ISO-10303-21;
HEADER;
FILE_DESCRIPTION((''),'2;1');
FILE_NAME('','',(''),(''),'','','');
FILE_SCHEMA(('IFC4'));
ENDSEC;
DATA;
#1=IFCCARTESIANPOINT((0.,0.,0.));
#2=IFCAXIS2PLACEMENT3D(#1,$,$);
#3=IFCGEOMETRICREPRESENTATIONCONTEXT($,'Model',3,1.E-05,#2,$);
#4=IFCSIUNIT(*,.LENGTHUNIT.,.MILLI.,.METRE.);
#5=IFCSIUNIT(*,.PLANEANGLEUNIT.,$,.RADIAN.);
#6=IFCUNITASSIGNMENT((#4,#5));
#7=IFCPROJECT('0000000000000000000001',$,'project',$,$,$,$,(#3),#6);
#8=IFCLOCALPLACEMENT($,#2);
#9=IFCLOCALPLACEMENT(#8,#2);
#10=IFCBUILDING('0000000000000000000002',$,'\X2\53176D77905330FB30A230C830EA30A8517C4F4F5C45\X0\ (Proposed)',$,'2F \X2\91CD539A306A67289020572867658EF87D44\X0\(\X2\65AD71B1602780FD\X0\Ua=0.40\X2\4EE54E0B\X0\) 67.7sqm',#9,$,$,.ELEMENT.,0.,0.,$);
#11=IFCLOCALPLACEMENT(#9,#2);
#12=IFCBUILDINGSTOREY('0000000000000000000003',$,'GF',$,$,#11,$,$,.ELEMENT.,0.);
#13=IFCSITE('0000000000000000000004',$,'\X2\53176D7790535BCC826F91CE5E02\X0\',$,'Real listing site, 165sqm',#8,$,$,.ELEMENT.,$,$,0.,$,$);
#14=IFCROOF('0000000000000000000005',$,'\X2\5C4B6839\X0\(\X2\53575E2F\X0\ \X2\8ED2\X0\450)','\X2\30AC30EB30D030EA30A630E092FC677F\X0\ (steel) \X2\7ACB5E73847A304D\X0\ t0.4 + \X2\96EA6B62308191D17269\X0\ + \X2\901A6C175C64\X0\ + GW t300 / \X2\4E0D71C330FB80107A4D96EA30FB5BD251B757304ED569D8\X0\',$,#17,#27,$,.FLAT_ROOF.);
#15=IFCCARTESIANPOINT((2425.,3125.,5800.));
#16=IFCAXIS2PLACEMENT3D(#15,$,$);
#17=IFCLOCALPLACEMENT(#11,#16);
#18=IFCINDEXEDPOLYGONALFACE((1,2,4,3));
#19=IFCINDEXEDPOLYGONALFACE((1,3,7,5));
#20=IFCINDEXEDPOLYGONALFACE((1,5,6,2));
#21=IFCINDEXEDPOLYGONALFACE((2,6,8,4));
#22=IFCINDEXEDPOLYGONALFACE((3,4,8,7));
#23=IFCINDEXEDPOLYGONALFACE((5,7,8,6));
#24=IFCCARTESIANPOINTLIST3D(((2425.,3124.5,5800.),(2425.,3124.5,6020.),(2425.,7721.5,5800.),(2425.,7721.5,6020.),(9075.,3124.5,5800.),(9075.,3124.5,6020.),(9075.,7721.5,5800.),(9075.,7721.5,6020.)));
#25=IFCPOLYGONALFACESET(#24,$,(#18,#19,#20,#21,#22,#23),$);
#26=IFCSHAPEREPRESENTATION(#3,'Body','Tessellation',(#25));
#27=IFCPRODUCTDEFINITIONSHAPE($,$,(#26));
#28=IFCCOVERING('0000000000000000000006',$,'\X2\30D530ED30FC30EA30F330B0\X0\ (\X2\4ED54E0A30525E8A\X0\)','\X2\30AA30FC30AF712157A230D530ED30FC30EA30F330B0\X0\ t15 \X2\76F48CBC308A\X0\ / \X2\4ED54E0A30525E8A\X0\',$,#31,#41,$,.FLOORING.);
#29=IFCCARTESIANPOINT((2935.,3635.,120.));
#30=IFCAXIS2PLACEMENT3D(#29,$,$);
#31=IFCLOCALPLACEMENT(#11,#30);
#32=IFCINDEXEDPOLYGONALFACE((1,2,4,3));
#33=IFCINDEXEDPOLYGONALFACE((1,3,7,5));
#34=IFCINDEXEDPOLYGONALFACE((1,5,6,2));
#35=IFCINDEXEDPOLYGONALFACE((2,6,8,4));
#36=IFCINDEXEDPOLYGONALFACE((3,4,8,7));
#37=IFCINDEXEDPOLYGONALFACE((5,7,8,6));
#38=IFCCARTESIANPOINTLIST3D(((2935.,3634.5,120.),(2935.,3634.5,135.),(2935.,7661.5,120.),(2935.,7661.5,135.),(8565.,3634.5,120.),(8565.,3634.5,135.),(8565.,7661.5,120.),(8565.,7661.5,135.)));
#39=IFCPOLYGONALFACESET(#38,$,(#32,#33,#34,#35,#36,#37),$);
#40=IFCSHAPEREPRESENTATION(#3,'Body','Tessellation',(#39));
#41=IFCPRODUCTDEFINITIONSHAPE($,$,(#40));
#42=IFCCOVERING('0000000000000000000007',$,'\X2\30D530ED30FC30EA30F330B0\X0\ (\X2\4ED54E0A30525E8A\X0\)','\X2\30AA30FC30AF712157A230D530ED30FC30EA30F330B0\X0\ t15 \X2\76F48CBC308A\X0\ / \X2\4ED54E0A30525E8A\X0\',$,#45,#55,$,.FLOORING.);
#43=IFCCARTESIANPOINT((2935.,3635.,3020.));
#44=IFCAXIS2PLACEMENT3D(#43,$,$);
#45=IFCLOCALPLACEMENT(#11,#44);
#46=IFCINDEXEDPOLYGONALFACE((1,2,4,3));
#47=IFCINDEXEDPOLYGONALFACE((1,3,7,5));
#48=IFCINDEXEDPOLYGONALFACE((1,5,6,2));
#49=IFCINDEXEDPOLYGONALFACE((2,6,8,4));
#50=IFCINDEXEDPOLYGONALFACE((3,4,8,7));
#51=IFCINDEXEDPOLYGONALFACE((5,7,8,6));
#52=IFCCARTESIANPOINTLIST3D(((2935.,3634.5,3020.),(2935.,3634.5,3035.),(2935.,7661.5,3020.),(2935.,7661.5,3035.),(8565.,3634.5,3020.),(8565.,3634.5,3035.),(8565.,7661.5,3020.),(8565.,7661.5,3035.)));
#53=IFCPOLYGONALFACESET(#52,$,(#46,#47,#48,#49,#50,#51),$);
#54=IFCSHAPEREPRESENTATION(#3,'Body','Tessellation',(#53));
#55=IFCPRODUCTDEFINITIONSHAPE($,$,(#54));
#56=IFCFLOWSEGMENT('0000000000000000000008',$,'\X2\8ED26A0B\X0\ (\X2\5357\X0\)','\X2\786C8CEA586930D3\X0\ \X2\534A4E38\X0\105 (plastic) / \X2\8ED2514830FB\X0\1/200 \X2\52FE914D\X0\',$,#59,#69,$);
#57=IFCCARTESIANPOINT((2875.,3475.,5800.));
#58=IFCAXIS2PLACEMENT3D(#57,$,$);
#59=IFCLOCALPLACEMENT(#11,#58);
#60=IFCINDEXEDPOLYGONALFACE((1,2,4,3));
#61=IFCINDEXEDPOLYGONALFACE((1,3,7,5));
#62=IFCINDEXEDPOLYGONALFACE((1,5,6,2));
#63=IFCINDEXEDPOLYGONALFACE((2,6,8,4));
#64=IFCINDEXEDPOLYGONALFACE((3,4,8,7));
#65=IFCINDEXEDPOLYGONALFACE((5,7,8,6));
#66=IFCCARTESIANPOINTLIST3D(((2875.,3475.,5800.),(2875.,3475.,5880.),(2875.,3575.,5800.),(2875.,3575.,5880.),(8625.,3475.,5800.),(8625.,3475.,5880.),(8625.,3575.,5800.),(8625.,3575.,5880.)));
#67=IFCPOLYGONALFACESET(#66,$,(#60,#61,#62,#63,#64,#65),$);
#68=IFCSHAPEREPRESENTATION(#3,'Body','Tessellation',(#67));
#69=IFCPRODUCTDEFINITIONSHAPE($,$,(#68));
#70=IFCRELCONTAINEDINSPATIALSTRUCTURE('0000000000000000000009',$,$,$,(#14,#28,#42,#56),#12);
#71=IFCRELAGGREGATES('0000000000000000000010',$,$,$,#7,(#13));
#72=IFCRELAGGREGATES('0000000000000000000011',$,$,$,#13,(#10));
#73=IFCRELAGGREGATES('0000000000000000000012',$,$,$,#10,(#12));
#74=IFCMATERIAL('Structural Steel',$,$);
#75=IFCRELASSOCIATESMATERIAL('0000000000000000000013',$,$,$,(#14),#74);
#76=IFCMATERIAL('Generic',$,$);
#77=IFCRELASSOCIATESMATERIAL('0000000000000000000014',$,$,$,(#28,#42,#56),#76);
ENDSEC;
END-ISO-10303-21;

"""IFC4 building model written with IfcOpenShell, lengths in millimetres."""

from ifc_helpers import new_model, si_unit, frame, frame_2d, origin, place, context, project, spatial, rectangle, extrude, material, element, save


model = new_model("IFC4")

# Units and contexts
model_context = context("Model", 3, precision=1e-05, world=origin())
ifc_project = project(units=[si_unit("LENGTHUNIT", "METRE", prefix="MILLI"), si_unit("PLANEANGLEUNIT", "RADIAN")], contexts=[model_context])

# Site, building, storey
site_placement = place(None, origin())
site = spatial("IfcSite", under=ifc_project, at=site_placement, Name="北海道富良野市", ObjectType="Real listing site, 165sqm", CompositionType="ELEMENT", RefElevation=0.0)
building_placement = place(site_placement, origin())
building = spatial("IfcBuilding", under=site, at=building_placement, Name="北海道・アトリエ兼住居 (Proposed)", ObjectType="2F 重厚な木造在来軸組(断熱性能Ua=0.40以下) 67.7sqm", CompositionType="ELEMENT", ElevationOfRefHeight=0.0, ElevationOfTerrain=0.0)
storey_placement = place(building_placement, origin())
storey = spatial("IfcBuildingStorey", under=building, at=storey_placement, Name="GF", CompositionType="ELEMENT", Elevation=0.0)

# Roof
ifc_material_1 = material(Name="Structural Steel")
for number, where, name in (
    (1, (2425.0, 3125.0, 5800.0), "屋根(南帯 軒450)"),
):
    element("IfcRoof", number, at=place(storey_placement, frame(where)), inside=storey, material=ifc_material_1, Name=name, Description="ガルバリウム鋼板 (steel) 立平葺き t0.4 + 雪止め金物 + 通気層 + GW t300 / 不燃・耐積雪・寒冷地仕様", PredefinedType="FLAT_ROOF", context=model_context, shape_type="SweptSolid", body=[
        extrude(rectangle(XDim=6650.0, YDim=4597.0, at=frame_2d((3325.0, 2298.0))), frame((2425.0, 3125.0, 5800.0)), (0.0, 0.0, 1.0), 220.0),
    ])

# Coverings
ifc_material_2 = material(Name="Generic")
covering_1_placement = place(storey_placement, frame((2935.0, 3635.0, 120.0)))
element("IfcCovering", 2, at=covering_1_placement, inside=storey, material=ifc_material_2, Name="フローリング (仕上げ床)", Description="オーク無垢フローリング t15 直貼り / 仕上げ床", PredefinedType="FLOORING", context=model_context, shape_type="SweptSolid", body=[
    extrude(rectangle(XDim=5630.0, YDim=4027.0, at=frame_2d((2815.0, 2013.0))), frame((2935.0, 3635.0, 120.0)), (0.0, 0.0, 1.0), 15.0),
])
covering_2_placement = place(storey_placement, frame((2935.0, 3635.0, 3020.0)))
element("IfcCovering", 3, at=covering_2_placement, inside=storey, material=ifc_material_2, Name="フローリング (仕上げ床)", Description="オーク無垢フローリング t15 直貼り / 仕上げ床", PredefinedType="FLOORING", context=model_context, shape_type="SweptSolid", body=[
    extrude(rectangle(XDim=5630.0, YDim=4027.0, at=frame_2d((2815.0, 2013.0))), frame((2935.0, 3635.0, 3020.0)), (0.0, 0.0, 1.0), 15.0),
])

# Flow segment
flow_segment_placement = place(storey_placement, frame((2875.0, 3475.0, 5800.0)))
element("IfcFlowSegment", 4, at=flow_segment_placement, inside=storey, material=ifc_material_2, Name="軒樋 (南)", Description="硬質塩ビ 半丸105 (plastic) / 軒先・1/200 勾配", context=model_context, shape_type="SweptSolid", body=[
    extrude(rectangle(XDim=5750.0, YDim=100.0, at=frame_2d((2875.0, 50.0))), frame((2875.0, 3475.0, 5800.0)), (0.0, 0.0, 1.0), 80.0),
])

save(model, "model.ifc")
